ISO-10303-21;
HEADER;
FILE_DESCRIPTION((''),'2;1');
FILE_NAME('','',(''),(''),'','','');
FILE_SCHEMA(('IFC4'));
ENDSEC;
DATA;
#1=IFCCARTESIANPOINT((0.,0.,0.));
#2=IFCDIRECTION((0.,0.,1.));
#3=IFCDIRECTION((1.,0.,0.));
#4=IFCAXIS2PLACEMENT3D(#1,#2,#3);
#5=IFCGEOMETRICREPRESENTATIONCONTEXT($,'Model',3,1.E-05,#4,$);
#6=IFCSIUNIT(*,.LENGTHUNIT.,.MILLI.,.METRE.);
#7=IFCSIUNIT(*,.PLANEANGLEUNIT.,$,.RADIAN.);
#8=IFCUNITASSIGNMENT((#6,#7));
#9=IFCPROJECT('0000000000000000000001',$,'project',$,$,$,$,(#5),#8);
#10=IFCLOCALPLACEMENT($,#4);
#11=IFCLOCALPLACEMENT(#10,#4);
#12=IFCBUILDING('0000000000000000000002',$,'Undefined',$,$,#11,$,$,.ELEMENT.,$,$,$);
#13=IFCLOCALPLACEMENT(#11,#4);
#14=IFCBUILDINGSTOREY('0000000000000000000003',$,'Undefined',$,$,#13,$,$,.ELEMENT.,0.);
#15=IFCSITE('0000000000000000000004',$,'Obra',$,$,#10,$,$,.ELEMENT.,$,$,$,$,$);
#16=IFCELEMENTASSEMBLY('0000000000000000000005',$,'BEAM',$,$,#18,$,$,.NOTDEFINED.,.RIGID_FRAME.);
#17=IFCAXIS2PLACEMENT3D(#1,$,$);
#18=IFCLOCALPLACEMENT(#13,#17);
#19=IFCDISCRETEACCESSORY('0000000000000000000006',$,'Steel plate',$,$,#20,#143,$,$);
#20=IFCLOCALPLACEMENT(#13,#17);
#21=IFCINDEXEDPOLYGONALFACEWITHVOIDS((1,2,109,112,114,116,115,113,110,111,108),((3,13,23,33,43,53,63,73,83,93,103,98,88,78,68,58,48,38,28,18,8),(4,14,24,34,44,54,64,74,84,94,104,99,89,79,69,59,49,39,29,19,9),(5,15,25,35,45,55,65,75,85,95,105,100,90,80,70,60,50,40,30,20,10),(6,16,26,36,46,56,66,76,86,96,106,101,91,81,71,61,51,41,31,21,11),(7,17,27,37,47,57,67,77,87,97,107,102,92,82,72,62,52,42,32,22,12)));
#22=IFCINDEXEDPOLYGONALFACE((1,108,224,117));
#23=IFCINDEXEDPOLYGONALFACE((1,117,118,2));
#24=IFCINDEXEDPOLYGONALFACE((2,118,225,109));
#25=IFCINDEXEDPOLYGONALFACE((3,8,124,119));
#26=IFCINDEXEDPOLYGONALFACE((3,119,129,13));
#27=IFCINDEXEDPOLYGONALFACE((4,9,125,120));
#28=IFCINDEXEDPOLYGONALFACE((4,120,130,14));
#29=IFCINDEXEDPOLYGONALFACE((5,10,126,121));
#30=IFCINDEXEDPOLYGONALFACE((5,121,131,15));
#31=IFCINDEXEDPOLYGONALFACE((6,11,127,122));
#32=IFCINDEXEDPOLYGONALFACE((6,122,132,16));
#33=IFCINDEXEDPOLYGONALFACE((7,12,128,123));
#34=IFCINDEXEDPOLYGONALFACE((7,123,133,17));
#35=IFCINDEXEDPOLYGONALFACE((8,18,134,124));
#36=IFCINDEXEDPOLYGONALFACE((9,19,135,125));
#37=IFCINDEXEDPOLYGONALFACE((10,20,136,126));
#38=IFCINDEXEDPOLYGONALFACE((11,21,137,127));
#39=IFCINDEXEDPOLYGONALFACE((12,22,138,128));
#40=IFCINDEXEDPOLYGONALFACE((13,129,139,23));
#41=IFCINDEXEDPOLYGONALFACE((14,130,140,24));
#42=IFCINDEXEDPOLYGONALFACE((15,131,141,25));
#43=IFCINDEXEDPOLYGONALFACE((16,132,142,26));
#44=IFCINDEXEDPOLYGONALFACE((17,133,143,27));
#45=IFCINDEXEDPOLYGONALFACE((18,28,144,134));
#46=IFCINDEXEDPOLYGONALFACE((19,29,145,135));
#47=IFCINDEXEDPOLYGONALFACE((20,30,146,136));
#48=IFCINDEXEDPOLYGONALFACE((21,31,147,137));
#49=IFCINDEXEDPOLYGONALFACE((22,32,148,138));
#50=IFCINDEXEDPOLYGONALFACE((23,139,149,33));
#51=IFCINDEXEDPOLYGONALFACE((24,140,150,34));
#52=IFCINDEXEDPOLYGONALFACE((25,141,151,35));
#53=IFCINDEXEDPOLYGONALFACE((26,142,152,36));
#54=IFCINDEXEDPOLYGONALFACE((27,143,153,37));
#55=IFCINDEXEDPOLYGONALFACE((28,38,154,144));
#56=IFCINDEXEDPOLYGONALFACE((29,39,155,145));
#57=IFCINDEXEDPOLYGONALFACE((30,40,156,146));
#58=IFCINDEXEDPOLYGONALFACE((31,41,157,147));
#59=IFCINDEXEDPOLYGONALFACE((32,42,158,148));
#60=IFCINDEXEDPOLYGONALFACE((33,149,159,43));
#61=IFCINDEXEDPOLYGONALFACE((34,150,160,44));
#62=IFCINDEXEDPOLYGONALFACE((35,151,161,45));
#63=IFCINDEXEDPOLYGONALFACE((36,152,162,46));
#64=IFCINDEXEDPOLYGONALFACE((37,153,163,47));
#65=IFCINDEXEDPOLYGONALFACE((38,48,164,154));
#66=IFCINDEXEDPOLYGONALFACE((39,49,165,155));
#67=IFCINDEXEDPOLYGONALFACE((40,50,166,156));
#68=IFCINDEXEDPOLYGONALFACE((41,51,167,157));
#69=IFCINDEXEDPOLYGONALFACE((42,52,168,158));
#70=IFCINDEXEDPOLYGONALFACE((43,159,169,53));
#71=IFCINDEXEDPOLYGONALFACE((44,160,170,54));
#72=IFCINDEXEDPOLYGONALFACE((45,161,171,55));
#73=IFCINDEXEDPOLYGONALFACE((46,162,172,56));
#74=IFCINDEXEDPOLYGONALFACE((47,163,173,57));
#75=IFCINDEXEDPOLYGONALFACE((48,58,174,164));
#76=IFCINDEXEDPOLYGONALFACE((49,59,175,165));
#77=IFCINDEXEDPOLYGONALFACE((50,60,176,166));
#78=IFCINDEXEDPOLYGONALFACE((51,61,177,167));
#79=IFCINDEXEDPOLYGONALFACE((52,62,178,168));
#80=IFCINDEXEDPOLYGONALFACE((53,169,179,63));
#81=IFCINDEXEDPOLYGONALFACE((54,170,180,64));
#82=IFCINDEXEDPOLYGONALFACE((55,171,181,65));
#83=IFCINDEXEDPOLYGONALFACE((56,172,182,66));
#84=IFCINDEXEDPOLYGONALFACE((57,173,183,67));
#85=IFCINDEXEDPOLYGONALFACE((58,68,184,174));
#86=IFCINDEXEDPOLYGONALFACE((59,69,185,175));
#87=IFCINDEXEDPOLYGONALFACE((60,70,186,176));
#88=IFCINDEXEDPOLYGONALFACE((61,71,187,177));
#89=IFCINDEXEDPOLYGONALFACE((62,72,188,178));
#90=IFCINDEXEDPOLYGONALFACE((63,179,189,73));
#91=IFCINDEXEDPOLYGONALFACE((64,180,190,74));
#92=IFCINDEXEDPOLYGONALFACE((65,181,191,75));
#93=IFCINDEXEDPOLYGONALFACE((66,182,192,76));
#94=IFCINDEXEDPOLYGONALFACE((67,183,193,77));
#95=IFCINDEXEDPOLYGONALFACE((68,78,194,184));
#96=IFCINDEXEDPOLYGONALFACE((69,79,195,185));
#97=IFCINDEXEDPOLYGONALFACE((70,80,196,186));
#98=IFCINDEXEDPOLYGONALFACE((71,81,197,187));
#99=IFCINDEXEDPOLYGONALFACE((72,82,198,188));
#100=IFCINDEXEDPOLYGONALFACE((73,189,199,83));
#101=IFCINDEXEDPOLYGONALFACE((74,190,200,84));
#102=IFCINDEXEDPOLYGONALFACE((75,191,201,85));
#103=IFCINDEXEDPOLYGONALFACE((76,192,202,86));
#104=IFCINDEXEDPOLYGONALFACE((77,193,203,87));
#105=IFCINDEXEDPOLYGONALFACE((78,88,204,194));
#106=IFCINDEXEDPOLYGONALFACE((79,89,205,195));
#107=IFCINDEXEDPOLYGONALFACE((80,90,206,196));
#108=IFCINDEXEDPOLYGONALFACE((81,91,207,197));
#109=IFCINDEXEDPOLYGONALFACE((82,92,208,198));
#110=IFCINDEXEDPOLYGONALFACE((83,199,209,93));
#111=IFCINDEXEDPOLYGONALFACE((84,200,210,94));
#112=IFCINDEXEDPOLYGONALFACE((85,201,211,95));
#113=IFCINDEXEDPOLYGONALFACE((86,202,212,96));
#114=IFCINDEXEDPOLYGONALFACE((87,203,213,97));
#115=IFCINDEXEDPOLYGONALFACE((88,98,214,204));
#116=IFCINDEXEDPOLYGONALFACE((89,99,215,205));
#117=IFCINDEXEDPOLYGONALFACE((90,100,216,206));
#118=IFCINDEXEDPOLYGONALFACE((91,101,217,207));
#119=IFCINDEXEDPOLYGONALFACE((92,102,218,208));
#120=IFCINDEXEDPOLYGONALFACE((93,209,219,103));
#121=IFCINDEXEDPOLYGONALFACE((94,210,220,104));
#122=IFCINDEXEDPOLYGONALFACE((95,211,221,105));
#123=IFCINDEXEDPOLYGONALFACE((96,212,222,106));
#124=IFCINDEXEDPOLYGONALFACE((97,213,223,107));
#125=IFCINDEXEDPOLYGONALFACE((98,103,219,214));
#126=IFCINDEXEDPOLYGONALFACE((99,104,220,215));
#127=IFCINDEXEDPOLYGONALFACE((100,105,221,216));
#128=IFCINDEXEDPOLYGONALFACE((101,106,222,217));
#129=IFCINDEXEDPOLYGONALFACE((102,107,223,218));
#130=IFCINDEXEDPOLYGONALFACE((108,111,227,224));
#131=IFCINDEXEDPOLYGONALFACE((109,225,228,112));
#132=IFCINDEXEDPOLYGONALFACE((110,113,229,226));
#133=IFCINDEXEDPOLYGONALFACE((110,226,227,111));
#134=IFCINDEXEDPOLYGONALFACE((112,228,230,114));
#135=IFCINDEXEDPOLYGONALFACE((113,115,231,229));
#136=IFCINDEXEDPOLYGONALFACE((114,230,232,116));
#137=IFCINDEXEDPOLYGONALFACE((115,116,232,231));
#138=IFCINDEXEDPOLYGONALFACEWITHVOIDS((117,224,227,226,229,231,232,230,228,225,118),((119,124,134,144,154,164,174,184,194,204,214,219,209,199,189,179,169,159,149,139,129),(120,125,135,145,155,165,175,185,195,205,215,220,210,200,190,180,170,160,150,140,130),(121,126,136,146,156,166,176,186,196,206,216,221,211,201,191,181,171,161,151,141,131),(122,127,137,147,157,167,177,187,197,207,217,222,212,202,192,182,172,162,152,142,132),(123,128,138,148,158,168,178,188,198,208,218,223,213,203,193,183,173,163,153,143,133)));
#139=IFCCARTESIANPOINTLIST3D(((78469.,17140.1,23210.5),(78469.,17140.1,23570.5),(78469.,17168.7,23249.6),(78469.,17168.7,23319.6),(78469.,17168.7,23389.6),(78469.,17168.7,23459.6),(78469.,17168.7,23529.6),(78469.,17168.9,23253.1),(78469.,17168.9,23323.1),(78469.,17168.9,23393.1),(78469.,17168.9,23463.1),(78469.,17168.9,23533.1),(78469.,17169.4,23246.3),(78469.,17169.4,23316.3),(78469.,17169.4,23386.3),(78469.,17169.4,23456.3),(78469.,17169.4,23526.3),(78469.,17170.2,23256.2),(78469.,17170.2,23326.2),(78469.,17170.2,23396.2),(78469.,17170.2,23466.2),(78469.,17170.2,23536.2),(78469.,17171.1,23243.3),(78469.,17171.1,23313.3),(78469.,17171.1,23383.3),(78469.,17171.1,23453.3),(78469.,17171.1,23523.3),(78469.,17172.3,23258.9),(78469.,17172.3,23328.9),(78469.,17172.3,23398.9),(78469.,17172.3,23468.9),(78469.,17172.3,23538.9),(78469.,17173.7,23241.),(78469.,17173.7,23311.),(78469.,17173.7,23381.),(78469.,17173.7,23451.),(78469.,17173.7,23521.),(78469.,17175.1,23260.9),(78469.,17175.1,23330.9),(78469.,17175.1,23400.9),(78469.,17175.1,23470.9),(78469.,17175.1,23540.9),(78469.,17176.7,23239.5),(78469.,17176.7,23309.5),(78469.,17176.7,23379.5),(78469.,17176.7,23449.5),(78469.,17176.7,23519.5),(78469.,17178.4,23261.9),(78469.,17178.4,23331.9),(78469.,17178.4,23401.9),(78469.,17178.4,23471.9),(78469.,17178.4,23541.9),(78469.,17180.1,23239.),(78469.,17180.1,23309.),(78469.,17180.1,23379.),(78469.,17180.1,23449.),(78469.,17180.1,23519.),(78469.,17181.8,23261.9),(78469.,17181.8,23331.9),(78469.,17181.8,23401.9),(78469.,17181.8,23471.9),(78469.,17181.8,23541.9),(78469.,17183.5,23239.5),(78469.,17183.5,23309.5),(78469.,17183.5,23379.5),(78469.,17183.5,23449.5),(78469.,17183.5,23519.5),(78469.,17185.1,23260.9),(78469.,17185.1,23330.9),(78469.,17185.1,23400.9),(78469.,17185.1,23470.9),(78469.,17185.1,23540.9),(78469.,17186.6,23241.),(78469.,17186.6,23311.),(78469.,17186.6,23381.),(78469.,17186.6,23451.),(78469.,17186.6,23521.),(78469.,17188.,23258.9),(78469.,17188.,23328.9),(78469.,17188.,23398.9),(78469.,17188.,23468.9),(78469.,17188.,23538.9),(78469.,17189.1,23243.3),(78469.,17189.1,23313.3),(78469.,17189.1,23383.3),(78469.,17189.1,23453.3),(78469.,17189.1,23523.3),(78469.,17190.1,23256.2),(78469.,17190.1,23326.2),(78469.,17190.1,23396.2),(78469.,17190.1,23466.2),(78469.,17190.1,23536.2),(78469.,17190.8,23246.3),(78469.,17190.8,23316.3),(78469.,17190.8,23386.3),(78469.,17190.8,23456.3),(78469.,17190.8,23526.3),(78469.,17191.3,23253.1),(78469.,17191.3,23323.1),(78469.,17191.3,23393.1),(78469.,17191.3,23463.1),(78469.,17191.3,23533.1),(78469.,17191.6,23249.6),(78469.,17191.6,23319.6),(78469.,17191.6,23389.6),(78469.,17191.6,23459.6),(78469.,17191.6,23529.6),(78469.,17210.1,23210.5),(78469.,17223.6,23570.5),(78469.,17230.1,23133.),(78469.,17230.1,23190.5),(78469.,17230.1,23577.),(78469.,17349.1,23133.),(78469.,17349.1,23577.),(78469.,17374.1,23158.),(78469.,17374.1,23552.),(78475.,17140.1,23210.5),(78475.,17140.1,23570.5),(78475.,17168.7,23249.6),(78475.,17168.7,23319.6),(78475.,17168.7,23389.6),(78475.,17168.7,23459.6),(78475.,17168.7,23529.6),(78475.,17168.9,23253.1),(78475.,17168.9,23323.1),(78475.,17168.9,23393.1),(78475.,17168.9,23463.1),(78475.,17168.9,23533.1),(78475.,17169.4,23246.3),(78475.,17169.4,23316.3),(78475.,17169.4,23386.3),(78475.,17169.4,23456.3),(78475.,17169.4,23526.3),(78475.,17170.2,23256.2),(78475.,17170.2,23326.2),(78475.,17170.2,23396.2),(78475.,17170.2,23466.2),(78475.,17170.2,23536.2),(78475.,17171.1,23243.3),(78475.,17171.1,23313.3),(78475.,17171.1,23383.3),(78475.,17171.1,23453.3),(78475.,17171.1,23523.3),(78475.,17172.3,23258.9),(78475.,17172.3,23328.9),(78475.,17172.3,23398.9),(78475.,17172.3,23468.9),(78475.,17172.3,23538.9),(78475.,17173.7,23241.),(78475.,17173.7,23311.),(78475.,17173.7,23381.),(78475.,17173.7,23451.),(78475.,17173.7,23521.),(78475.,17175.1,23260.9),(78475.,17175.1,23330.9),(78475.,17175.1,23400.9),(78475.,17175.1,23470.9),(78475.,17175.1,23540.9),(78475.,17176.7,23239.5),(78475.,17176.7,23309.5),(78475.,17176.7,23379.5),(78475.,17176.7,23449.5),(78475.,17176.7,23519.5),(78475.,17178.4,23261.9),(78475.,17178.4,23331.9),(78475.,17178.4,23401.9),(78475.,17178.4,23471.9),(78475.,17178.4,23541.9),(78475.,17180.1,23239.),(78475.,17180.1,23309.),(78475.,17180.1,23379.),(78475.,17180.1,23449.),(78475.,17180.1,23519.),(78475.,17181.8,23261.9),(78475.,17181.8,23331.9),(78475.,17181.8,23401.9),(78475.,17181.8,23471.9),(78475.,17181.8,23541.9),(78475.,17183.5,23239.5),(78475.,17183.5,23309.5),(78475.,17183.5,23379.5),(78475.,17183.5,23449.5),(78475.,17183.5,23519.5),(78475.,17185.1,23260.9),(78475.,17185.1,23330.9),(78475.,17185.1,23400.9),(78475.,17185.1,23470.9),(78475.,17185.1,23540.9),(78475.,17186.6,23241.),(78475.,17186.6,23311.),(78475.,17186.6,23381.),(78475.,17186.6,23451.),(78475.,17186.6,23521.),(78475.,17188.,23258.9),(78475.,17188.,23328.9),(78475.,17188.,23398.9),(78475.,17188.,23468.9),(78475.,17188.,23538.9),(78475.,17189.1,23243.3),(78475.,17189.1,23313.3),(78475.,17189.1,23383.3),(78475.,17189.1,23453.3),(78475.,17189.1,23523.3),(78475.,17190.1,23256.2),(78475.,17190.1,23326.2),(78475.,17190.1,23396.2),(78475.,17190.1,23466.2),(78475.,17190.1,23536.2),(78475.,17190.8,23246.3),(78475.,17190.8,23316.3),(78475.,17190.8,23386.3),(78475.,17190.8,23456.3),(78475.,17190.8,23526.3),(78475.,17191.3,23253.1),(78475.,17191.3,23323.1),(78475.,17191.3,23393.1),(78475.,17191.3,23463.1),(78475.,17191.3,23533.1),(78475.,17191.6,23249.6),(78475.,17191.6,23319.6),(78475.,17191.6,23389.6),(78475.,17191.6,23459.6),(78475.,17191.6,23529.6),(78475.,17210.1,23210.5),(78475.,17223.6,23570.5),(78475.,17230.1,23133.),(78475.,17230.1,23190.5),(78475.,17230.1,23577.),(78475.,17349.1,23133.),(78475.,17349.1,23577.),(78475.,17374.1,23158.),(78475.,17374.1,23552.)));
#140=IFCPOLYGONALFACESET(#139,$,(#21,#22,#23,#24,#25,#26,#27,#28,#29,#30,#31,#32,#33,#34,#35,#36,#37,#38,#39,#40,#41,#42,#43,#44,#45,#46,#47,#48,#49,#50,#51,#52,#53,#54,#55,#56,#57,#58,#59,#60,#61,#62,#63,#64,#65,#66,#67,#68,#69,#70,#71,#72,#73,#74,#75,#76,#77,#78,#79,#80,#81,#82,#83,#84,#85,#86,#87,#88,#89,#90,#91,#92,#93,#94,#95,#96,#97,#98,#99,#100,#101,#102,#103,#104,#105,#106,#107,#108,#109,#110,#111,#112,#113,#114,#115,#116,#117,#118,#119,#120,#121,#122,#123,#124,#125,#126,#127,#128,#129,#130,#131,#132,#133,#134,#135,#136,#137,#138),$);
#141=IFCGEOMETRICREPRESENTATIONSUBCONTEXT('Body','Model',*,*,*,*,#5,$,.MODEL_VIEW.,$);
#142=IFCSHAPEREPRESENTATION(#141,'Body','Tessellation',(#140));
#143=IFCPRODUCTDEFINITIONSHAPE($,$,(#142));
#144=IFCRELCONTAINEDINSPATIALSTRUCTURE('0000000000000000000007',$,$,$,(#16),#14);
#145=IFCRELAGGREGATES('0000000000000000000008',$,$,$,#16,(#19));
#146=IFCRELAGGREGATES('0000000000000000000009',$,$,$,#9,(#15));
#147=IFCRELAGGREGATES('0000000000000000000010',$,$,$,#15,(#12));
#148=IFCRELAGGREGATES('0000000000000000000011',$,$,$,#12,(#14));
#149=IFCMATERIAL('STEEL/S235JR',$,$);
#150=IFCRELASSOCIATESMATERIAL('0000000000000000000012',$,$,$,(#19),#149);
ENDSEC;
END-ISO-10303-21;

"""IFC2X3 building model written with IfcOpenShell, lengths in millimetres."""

from ifc_helpers import new_model, si_unit, frame, origin_with_axes, origin_2d_with_axis, place, context, subcontext, project, spatial, polyline, circle, outline, extrude, source, transform, mapped, material, element, aggregate, save


model = new_model("IFC2X3")

# Units and contexts
model_context = context("Model", 3, precision=1e-05, world=origin_with_axes())
body_context = subcontext(model_context, "Body", "Model", "MODEL_VIEW")
ifc_project = project(units=[si_unit("LENGTHUNIT", "METRE", prefix="MILLI"), si_unit("PLANEANGLEUNIT", "RADIAN")], contexts=[model_context])

# Site, building, storey
site_placement = place(None, origin_with_axes())
site = spatial("IfcSite", under=ifc_project, at=site_placement, Name="Obra", CompositionType="ELEMENT")
building_placement = place(site_placement, origin_with_axes())
building = spatial("IfcBuilding", under=site, at=building_placement, Name="Undefined", CompositionType="ELEMENT")
storey_placement = place(building_placement, origin_with_axes())
storey = spatial("IfcBuildingStorey", under=building, at=storey_placement, Name="Undefined", CompositionType="ELEMENT", Elevation=0.0)

# Element assembly, discrete accessory, opening
assembly_1_placement = place(storey_placement, origin_with_axes())
assembly_1 = element("IfcElementAssembly", 1, at=assembly_1_placement, inside=storey, Name="BEAM", AssemblyPlace="NOTDEFINED", PredefinedType="RIGID_FRAME")
ifc_material_1 = material(Name="STEEL/S235JR")
shared_shape_1 = source(origin_with_axes(), body_context, "Body", "SweptSolid", [
    extrude(circle(Radius=11.5, at=origin_2d_with_axis()), frame((0.0, 3.6, 0.0), z_axis=(0.0, 1.0, 0.0), x_axis=(1.0, 0.0, 0.0)), (0.0, 0.0, 1.0), 6.2),
])
discrete_accessory_1_placement = place(assembly_1_placement, frame((78472.0, 17374.1, 23158.0), z_axis=(-1.0, 0.0, 0.0), x_axis=(0.0, -0.707107, -0.707107)))
discrete_accessory_1 = element("IfcDiscreteAccessory", 2, at=discrete_accessory_1_placement, material=ifc_material_1, Name="Steel plate", context=body_context, shape_type="SweptSolid", body=[
    extrude(outline(polyline([(0.0, 0.0), (35.4, 0.0), (119.5, 84.1), (78.8, 124.8), (78.8, 153.1), (128.3, 202.6), (-126.2, 457.1), (-185.3, 398.1), (-194.5, 398.1), (-194.5, 398.1), (-278.6, 314.0), (-278.6, 278.6), (0.0, 0.0)])), frame((0.0, 0.0, -3.0), z_axis=(0.0, 0.0, 1.0), x_axis=(1.0, 0.0, 0.0)), (0.0, 0.0, 1.0), 6.0),
])
opening_1_placement = place(assembly_1_placement, frame((78465.2, 17220.1, 23570.5), z_axis=(0.0, -1.0, 0.0), x_axis=(0.0, 0.0, -1.0)))
element("IfcOpeningElement", 3, at=opening_1_placement, cuts=discrete_accessory_1, ObjectType="Opening", context=body_context, shape_type="MappedRepresentation", body=[
    mapped(shared_shape_1, transform((40.0, 0.0, 40.0))),
    mapped(shared_shape_1, transform((110.0, 0.0, 40.0))),
    mapped(shared_shape_1, transform((180.0, 0.0, 40.0))),
    mapped(shared_shape_1, transform((250.0, 0.0, 40.0))),
    mapped(shared_shape_1, transform((320.0, 0.0, 40.0))),
])

aggregate(assembly_1, [discrete_accessory_1])

save(model, "model.ifc")
